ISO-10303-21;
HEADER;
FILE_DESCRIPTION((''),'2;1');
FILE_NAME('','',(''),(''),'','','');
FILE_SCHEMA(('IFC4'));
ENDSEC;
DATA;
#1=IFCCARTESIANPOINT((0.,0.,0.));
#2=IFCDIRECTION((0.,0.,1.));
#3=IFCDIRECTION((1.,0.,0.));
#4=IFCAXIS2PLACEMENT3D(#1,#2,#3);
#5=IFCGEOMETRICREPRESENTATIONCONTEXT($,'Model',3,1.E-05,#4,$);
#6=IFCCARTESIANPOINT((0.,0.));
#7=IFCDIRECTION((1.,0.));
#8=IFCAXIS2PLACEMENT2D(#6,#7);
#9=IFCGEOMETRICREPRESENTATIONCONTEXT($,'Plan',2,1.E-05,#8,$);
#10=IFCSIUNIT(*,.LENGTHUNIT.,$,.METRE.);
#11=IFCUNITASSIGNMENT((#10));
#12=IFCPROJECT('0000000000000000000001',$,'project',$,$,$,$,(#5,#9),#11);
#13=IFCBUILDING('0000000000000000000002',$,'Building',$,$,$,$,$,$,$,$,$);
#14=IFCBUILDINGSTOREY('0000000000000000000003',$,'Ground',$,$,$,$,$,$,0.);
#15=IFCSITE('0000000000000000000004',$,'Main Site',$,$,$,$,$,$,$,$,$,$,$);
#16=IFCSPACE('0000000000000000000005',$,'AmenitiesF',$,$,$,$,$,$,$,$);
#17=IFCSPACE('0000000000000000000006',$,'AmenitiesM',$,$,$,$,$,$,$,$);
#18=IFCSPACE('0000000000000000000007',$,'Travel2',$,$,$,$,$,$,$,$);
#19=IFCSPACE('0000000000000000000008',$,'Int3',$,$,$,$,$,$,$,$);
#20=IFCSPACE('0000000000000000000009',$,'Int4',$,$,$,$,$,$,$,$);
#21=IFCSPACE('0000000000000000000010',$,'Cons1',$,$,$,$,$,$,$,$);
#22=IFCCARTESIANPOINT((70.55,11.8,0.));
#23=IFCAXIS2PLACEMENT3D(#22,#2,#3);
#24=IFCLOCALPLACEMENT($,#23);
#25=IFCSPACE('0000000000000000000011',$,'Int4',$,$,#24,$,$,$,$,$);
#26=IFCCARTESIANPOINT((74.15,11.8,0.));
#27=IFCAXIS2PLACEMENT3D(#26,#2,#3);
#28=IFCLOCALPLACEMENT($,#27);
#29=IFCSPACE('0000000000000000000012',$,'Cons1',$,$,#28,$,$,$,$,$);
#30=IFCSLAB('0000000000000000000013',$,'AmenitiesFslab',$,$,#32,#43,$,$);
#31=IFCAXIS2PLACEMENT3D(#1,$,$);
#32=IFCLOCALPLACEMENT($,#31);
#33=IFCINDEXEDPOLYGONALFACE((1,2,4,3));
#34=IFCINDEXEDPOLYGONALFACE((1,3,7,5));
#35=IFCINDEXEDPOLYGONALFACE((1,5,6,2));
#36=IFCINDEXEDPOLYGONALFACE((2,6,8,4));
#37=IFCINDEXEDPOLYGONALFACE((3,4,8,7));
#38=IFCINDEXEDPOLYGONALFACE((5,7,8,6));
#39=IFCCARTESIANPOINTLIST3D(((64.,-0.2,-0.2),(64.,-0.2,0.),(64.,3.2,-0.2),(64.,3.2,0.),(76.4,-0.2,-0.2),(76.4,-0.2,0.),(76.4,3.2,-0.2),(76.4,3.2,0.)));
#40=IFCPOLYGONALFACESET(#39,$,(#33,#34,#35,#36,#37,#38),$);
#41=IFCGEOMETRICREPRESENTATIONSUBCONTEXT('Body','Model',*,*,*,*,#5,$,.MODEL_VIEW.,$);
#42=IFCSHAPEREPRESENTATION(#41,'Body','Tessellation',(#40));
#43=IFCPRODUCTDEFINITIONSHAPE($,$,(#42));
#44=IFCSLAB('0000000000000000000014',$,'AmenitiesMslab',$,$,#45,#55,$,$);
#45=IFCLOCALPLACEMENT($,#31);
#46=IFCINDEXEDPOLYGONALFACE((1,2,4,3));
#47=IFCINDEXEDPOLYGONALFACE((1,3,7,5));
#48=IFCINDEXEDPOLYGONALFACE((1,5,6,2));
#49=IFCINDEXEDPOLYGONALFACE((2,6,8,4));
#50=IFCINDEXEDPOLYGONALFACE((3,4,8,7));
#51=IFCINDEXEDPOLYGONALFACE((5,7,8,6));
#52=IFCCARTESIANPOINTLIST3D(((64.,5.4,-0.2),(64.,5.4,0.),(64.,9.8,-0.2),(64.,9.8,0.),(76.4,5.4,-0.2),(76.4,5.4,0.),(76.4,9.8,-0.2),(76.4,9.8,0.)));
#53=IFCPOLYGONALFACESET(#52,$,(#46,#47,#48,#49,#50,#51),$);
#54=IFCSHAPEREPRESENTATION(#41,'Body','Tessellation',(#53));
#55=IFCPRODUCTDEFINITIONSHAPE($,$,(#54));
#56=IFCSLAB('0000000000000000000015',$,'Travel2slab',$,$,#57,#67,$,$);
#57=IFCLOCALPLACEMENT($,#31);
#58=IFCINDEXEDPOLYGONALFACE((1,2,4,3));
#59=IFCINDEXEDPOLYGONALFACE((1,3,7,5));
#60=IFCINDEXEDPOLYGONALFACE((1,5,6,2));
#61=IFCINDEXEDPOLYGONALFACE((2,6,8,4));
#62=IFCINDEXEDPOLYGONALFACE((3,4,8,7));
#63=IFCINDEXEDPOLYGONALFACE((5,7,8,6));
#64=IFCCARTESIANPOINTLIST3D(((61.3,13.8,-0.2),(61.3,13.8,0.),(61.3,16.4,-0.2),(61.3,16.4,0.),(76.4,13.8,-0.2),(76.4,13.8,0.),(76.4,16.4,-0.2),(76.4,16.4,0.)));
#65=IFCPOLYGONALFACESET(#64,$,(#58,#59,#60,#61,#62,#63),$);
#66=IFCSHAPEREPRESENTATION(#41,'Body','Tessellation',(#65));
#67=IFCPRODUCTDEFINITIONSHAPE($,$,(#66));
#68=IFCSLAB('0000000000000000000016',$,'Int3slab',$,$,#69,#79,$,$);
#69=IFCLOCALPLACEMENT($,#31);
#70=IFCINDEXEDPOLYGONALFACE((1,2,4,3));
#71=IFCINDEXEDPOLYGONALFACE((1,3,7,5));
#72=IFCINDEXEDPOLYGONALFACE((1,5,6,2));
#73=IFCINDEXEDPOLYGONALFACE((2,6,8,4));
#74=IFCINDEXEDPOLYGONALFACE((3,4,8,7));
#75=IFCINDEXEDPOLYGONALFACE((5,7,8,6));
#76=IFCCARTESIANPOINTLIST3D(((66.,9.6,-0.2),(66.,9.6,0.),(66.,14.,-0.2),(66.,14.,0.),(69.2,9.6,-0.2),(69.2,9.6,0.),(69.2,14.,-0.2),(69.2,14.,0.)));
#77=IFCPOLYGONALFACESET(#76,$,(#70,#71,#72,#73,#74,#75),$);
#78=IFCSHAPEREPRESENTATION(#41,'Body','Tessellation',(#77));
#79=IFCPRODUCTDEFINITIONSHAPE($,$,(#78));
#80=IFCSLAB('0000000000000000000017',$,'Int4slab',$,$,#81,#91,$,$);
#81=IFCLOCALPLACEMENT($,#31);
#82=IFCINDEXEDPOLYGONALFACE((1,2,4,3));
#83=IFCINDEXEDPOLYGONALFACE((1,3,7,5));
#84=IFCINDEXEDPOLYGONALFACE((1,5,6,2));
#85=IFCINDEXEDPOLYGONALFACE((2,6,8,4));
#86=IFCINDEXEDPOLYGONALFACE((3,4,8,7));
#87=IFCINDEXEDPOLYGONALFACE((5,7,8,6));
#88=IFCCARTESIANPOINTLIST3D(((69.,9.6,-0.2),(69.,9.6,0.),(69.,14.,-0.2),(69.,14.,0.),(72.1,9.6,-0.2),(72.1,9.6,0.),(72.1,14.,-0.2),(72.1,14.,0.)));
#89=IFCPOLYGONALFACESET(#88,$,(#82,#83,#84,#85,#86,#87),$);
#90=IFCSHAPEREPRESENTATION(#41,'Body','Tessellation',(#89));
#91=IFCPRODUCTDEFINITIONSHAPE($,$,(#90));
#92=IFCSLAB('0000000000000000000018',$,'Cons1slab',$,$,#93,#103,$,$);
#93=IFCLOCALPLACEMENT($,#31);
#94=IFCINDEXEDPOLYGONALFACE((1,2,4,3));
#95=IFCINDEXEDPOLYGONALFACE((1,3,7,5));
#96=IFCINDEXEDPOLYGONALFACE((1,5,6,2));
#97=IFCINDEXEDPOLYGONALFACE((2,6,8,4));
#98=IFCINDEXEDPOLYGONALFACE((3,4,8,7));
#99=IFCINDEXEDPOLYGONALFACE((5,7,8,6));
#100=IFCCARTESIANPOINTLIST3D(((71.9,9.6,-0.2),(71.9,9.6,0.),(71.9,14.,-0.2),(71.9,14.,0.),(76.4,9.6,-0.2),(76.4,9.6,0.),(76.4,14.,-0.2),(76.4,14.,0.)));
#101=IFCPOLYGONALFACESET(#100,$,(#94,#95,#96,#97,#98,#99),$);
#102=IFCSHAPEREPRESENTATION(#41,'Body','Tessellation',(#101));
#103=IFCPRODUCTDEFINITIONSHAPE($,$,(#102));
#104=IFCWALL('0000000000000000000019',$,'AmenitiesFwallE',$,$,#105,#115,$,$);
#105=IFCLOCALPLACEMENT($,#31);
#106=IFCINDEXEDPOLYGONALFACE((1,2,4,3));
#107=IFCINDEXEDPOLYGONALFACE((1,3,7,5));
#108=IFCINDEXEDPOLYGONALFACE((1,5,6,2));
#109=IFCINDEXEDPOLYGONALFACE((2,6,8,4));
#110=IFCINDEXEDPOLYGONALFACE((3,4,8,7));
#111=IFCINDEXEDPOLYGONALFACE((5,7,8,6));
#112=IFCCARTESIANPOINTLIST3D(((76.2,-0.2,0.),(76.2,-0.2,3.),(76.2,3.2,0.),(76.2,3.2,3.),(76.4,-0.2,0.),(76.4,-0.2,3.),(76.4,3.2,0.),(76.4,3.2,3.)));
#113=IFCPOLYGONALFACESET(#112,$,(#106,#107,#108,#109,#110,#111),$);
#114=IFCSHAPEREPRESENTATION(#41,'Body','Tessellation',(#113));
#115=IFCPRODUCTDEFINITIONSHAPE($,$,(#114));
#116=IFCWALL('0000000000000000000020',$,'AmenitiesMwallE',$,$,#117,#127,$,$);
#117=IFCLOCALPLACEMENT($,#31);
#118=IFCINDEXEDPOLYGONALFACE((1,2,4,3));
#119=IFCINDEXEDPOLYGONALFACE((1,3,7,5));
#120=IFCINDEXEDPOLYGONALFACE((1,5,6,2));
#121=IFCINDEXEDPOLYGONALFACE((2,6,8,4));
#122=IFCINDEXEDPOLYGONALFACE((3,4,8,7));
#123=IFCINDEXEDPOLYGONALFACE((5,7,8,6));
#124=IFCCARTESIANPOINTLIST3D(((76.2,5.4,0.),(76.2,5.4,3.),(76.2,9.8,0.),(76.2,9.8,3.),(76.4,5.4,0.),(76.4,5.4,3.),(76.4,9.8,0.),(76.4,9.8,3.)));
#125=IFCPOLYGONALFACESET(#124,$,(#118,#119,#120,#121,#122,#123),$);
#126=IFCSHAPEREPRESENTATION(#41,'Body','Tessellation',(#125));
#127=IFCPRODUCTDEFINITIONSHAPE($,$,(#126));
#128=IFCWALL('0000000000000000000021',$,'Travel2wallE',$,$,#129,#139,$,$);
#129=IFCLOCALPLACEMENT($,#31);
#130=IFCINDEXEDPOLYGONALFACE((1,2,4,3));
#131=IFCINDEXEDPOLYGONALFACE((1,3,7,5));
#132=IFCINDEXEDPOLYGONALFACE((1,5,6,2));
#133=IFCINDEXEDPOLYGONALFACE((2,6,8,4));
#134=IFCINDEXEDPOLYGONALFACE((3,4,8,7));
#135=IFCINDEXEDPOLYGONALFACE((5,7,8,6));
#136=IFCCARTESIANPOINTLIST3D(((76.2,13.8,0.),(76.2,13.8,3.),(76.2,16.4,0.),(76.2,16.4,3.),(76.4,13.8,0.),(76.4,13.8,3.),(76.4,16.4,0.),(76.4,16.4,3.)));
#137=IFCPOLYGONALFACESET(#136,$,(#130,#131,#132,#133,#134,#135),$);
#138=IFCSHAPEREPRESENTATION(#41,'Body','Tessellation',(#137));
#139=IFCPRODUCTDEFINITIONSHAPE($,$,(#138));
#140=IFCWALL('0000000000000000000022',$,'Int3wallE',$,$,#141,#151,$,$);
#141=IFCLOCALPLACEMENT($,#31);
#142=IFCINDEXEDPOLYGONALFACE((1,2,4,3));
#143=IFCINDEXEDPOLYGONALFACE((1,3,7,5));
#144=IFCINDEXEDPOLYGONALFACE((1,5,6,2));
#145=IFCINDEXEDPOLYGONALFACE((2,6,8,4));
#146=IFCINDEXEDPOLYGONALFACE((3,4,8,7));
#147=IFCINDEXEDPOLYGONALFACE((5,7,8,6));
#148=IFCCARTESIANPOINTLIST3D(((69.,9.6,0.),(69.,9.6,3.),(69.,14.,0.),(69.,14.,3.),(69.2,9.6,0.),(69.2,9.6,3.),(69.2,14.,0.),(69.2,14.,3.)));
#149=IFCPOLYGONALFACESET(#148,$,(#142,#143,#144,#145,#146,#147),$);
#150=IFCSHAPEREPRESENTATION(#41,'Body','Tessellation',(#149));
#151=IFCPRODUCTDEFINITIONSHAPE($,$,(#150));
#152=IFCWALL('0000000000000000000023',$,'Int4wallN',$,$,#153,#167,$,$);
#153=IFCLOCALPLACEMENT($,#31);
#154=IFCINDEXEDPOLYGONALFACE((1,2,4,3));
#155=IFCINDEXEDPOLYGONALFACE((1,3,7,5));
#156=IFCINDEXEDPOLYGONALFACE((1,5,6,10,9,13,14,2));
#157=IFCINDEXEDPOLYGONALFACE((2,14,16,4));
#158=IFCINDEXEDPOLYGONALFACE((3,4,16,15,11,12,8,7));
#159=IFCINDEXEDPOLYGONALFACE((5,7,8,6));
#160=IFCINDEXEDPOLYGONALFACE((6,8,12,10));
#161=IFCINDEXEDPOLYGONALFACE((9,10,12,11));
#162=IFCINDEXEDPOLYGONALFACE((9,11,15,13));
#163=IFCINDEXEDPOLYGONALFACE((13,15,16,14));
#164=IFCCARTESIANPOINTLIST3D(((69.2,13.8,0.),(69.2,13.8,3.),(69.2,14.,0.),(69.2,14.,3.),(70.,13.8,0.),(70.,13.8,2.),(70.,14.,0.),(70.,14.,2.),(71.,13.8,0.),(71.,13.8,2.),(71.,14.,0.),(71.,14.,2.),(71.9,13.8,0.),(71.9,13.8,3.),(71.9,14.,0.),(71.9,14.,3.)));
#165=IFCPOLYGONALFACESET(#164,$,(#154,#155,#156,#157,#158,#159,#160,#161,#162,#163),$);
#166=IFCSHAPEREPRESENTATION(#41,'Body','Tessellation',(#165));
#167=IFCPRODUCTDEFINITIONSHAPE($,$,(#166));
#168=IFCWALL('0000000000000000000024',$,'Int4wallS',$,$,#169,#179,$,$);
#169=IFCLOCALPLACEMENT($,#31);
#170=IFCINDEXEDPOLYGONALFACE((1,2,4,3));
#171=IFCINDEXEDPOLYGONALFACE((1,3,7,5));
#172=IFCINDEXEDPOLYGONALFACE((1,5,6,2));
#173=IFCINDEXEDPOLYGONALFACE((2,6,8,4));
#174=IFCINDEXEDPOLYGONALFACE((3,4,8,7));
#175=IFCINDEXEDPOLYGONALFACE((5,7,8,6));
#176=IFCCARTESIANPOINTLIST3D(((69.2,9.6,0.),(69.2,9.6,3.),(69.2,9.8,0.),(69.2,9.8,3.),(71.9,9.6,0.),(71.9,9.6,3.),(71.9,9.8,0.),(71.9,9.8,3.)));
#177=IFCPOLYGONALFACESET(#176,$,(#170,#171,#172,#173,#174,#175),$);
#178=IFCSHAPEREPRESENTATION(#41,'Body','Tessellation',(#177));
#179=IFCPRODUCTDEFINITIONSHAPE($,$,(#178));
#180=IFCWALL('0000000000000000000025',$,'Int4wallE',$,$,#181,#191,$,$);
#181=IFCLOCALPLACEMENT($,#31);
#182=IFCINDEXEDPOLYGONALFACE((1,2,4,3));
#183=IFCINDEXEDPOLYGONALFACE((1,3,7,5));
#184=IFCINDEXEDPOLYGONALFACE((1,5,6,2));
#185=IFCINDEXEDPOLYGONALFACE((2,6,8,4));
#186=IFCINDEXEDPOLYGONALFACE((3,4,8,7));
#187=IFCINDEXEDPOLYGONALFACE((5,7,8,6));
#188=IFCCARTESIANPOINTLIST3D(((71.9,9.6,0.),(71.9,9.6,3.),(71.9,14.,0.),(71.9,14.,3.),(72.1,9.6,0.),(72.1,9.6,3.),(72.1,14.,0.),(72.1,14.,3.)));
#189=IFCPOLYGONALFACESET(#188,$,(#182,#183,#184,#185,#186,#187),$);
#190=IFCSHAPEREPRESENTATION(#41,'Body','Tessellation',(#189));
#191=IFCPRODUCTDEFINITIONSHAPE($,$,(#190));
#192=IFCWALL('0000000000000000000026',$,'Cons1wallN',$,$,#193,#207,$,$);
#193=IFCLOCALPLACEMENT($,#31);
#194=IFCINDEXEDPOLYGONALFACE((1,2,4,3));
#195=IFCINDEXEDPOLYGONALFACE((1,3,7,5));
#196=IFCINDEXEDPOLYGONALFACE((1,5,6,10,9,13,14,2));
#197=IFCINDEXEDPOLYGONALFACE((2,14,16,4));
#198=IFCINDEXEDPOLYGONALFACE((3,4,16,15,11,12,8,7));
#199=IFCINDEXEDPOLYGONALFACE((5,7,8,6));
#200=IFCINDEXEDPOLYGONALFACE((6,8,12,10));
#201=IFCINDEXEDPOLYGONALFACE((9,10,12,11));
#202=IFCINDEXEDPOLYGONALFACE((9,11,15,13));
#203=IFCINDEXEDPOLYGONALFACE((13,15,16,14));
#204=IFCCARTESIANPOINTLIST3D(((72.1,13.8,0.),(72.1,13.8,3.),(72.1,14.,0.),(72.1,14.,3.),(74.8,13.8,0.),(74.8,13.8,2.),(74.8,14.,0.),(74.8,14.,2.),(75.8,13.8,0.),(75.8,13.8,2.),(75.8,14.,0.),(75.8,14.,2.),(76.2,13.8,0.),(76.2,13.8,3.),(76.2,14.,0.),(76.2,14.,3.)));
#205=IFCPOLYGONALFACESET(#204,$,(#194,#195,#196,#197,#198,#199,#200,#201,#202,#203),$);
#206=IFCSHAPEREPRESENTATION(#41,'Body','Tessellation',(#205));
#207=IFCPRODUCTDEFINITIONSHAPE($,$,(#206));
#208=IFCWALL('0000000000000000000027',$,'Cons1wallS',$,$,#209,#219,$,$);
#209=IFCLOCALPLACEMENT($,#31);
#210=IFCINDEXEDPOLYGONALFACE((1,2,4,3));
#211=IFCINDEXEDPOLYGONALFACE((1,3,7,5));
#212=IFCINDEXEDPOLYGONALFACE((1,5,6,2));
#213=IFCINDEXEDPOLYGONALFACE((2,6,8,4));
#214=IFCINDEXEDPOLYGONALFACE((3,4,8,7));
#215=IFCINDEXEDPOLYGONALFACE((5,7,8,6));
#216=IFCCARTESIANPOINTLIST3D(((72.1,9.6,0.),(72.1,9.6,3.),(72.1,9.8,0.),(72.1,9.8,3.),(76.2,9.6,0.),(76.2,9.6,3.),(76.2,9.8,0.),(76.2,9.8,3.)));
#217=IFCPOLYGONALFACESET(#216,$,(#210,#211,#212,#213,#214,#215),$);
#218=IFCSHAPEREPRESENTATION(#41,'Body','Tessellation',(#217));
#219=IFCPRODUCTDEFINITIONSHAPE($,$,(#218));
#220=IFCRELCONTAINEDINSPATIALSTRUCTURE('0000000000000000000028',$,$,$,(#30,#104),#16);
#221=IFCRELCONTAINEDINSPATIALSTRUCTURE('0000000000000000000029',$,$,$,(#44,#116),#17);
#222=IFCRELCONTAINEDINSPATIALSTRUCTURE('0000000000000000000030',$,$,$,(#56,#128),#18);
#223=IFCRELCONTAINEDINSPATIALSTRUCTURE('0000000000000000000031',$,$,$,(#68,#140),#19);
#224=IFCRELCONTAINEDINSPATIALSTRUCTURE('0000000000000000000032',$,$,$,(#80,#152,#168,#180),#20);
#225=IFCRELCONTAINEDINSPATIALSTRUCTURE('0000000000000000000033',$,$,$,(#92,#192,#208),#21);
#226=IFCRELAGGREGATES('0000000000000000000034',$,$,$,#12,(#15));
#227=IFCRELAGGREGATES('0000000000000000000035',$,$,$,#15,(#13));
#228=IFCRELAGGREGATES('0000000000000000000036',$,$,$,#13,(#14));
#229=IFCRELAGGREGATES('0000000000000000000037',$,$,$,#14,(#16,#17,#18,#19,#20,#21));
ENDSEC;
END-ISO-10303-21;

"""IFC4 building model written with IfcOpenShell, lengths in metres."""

from ifc_helpers import new_model, si_unit, frame, origin_with_axes, origin_2d_with_axis, place, context, subcontext, project, spatial, indexed_curve, rectangle, outline, extrude, element, save


model = new_model("IFC4")

# Units and contexts
model_context = context("Model", 3, precision=1e-05, world=origin_with_axes())
plan_context = context("Plan", 2, precision=1e-05, world=origin_2d_with_axis())
body_context = subcontext(model_context, "Body", "Model", "MODEL_VIEW")
ifc_project = project(units=[si_unit("LENGTHUNIT", "METRE")], contexts=[model_context, plan_context])

# Site, building, storey, space
site = spatial("IfcSite", under=ifc_project, Name="Main Site")
building = spatial("IfcBuilding", under=site, Name="Building")
storey = spatial("IfcBuildingStorey", under=building, Name="Ground", Elevation=0.0)
space_1 = spatial("IfcSpace", under=storey, Name="AmenitiesF")

# Slab
slab_1_placement = place(None, frame((70.2, 1.5, -0.2), z_axis=(0.0, 0.0, 1.0), x_axis=(1.0, 0.0, 0.0)))
element("IfcSlab", 1, at=slab_1_placement, inside=space_1, Name="AmenitiesFslab", context=body_context, shape_type="SweptSolid", body=[
    extrude(rectangle(XDim=12.4, YDim=3.4), origin_with_axes(), (0.0, 0.0, 1.0), 0.2),
])

# Shared definitions
space_2 = spatial("IfcSpace", under=storey, Name="AmenitiesM")

# Slab
slab_2_placement = place(None, frame((70.2, 7.6, -0.2), z_axis=(0.0, 0.0, 1.0), x_axis=(1.0, 0.0, 0.0)))
element("IfcSlab", 2, at=slab_2_placement, inside=space_2, Name="AmenitiesMslab", context=body_context, shape_type="SweptSolid", body=[
    extrude(rectangle(XDim=12.4, YDim=4.4), origin_with_axes(), (0.0, 0.0, 1.0), 0.2),
])

# Shared definitions
space_3 = spatial("IfcSpace", under=storey, Name="Travel2")

# Slab
slab_3_placement = place(None, frame((68.85, 15.1, -0.2), z_axis=(0.0, 0.0, 1.0), x_axis=(1.0, 0.0, 0.0)))
element("IfcSlab", 3, at=slab_3_placement, inside=space_3, Name="Travel2slab", context=body_context, shape_type="SweptSolid", body=[
    extrude(rectangle(XDim=15.1, YDim=2.6), origin_with_axes(), (0.0, 0.0, 1.0), 0.2),
])

# Shared definitions
space_4 = spatial("IfcSpace", under=storey, Name="Int3")

# Slab
slab_4_placement = place(None, frame((67.6, 11.8, -0.2), z_axis=(0.0, 0.0, 1.0), x_axis=(1.0, 0.0, 0.0)))
element("IfcSlab", 4, at=slab_4_placement, inside=space_4, Name="Int3slab", context=body_context, shape_type="SweptSolid", body=[
    extrude(rectangle(XDim=3.2, YDim=4.4), origin_with_axes(), (0.0, 0.0, 1.0), 0.2),
])

# Shared definitions
space_5 = spatial("IfcSpace", under=storey, Name="Int4")

# Slab
slab_5_placement = place(None, frame((70.55, 11.8, -0.2), z_axis=(0.0, 0.0, 1.0), x_axis=(1.0, 0.0, 0.0)))
element("IfcSlab", 5, at=slab_5_placement, inside=space_5, Name="Int4slab", context=body_context, shape_type="SweptSolid", body=[
    extrude(rectangle(XDim=3.1, YDim=4.4), origin_with_axes(), (0.0, 0.0, 1.0), 0.2),
])

# Shared definitions
space_6 = spatial("IfcSpace", under=storey, Name="Cons1")

# Slab
slab_6_placement = place(None, frame((74.15, 11.8, -0.2), z_axis=(0.0, 0.0, 1.0), x_axis=(1.0, 0.0, 0.0)))
element("IfcSlab", 6, at=slab_6_placement, inside=space_6, Name="Cons1slab", context=body_context, shape_type="SweptSolid", body=[
    extrude(rectangle(XDim=4.5, YDim=4.4), origin_with_axes(), (0.0, 0.0, 1.0), 0.2),
])

# Walls
wall_1_placement = place(None, frame((76.4, -0.2, 0.0), z_axis=(0.0, 0.0, 1.0), x_axis=(0.0, 1.0, 0.0)))
element("IfcWall", 7, at=wall_1_placement, inside=space_1, Name="AmenitiesFwallE", context=body_context, shape_type="SweptSolid", body=[
    extrude(outline(indexed_curve([(0.0, 0.0), (0.0, 0.2), (3.4, 0.2), (3.4, 0.0), (0.0, 0.0)], self_intersect=False)), origin_with_axes(), (0.0, 0.0, 1.0), 3.0),
])
wall_2_placement = place(None, frame((76.4, 5.4, 0.0), z_axis=(0.0, 0.0, 1.0), x_axis=(0.0, 1.0, 0.0)))
element("IfcWall", 8, at=wall_2_placement, inside=space_2, Name="AmenitiesMwallE", context=body_context, shape_type="SweptSolid", body=[
    extrude(outline(indexed_curve([(0.0, 0.0), (0.0, 0.2), (4.4, 0.2), (4.4, 0.0), (0.0, 0.0)], self_intersect=False)), origin_with_axes(), (0.0, 0.0, 1.0), 3.0),
])
wall_3_placement = place(None, frame((76.4, 13.8, 0.0), z_axis=(0.0, 0.0, 1.0), x_axis=(0.0, 1.0, 0.0)))
element("IfcWall", 9, at=wall_3_placement, inside=space_3, Name="Travel2wallE", context=body_context, shape_type="SweptSolid", body=[
    extrude(outline(indexed_curve([(0.0, 0.0), (0.0, 0.2), (2.6, 0.2), (2.6, 0.0), (0.0, 0.0)], self_intersect=False)), origin_with_axes(), (0.0, 0.0, 1.0), 3.0),
])
wall_4_placement = place(None, frame((69.2, 9.6, 0.0), z_axis=(0.0, 0.0, 1.0), x_axis=(0.0, 1.0, 0.0)))
element("IfcWall", 10, at=wall_4_placement, inside=space_4, Name="Int3wallE", context=body_context, shape_type="SweptSolid", body=[
    extrude(outline(indexed_curve([(0.0, 0.0), (0.0, 0.2), (4.4, 0.2), (4.4, 0.0), (0.0, 0.0)], self_intersect=False)), origin_with_axes(), (0.0, 0.0, 1.0), 3.0),
])

# Wall
wall_5_placement = place(None, frame((69.2, 13.8, 0.0), z_axis=(0.0, 0.0, 1.0), x_axis=(1.0, 0.0, 0.0)))
wall_5 = element("IfcWall", 11, at=wall_5_placement, inside=space_5, Name="Int4wallN", context=body_context, shape_type="SweptSolid", body=[
    extrude(outline(indexed_curve([(0.0, 0.0), (0.0, 0.2), (2.7, 0.2), (2.7, 0.0), (0.0, 0.0)], self_intersect=False)), origin_with_axes(), (0.0, 0.0, 1.0), 3.0),
])

# Shared definitions
space_7_placement = place(None, frame((70.55, 11.8, 0.0), z_axis=(0.0, 0.0, 1.0), x_axis=(1.0, 0.0, 0.0)))
space_7 = spatial("IfcSpace", at=space_7_placement, Name="Int4")

# Opening
opening_1_placement = place(wall_5_placement, frame((0.8, 0.0, 0.0), z_axis=(0.0, 0.0, 1.0), x_axis=(1.0, 0.0, 0.0)))
element("IfcOpeningElement", 12, at=opening_1_placement, inside=space_7, cuts=wall_5, context=body_context, shape_type="SweptSolid", body=[
    extrude(outline(indexed_curve([(0.0, 0.0), (0.0, 0.4), (1.0, 0.4), (1.0, 0.0), (0.0, 0.0)], self_intersect=False)), origin_with_axes(), (0.0, 0.0, 1.0), 2.0),
])

# Walls
wall_6_placement = place(None, frame((69.2, 9.6, 0.0), z_axis=(0.0, 0.0, 1.0), x_axis=(1.0, 0.0, 0.0)))
element("IfcWall", 13, at=wall_6_placement, inside=space_5, Name="Int4wallS", context=body_context, shape_type="SweptSolid", body=[
    extrude(outline(indexed_curve([(0.0, 0.0), (0.0, 0.2), (2.7, 0.2), (2.7, 0.0), (0.0, 0.0)], self_intersect=False)), origin_with_axes(), (0.0, 0.0, 1.0), 3.0),
])
for number, where, z_axis, x_axis, name in (
    (14, (72.1, 9.6, 0.0), (0.0, 0.0, 1.0), (0.0, 1.0, 0.0), "Int4wallE"),
):
    element("IfcWall", number, at=place(None, frame(where, z_axis=z_axis, x_axis=x_axis)), inside=space_5, Name=name, context=body_context, shape_type="SweptSolid", body=[
        extrude(outline(indexed_curve([(0.0, 0.0), (0.0, 0.2), (4.4, 0.2), (4.4, 0.0), (0.0, 0.0)], self_intersect=False)), origin_with_axes(), (0.0, 0.0, 1.0), 3.0),
    ])

# Wall
wall_7_placement = place(None, frame((72.1, 13.8, 0.0), z_axis=(0.0, 0.0, 1.0), x_axis=(1.0, 0.0, 0.0)))
wall_7 = element("IfcWall", 15, at=wall_7_placement, inside=space_6, Name="Cons1wallN", context=body_context, shape_type="SweptSolid", body=[
    extrude(outline(indexed_curve([(0.0, 0.0), (0.0, 0.2), (4.1, 0.2), (4.1, 0.0), (0.0, 0.0)], self_intersect=False)), origin_with_axes(), (0.0, 0.0, 1.0), 3.0),
])

# Shared definitions
space_8_placement = place(None, frame((74.15, 11.8, 0.0), z_axis=(0.0, 0.0, 1.0), x_axis=(1.0, 0.0, 0.0)))
space_8 = spatial("IfcSpace", at=space_8_placement, Name="Cons1")

# Opening
opening_2_placement = place(wall_7_placement, frame((2.7, 0.0, 0.0), z_axis=(0.0, 0.0, 1.0), x_axis=(1.0, 0.0, 0.0)))
element("IfcOpeningElement", 16, at=opening_2_placement, inside=space_8, cuts=wall_7, context=body_context, shape_type="SweptSolid", body=[
    extrude(outline(indexed_curve([(0.0, 0.0), (0.0, 0.4), (1.0, 0.4), (1.0, 0.0), (0.0, 0.0)], self_intersect=False)), origin_with_axes(), (0.0, 0.0, 1.0), 2.0),
])

# Wall
wall_8_placement = place(None, frame((72.1, 9.6, 0.0), z_axis=(0.0, 0.0, 1.0), x_axis=(1.0, 0.0, 0.0)))
element("IfcWall", 17, at=wall_8_placement, inside=space_6, Name="Cons1wallS", context=body_context, shape_type="SweptSolid", body=[
    extrude(outline(indexed_curve([(0.0, 0.0), (0.0, 0.2), (4.1, 0.2), (4.1, 0.0), (0.0, 0.0)], self_intersect=False)), origin_with_axes(), (0.0, 0.0, 1.0), 3.0),
])

save(model, "model.ifc")
